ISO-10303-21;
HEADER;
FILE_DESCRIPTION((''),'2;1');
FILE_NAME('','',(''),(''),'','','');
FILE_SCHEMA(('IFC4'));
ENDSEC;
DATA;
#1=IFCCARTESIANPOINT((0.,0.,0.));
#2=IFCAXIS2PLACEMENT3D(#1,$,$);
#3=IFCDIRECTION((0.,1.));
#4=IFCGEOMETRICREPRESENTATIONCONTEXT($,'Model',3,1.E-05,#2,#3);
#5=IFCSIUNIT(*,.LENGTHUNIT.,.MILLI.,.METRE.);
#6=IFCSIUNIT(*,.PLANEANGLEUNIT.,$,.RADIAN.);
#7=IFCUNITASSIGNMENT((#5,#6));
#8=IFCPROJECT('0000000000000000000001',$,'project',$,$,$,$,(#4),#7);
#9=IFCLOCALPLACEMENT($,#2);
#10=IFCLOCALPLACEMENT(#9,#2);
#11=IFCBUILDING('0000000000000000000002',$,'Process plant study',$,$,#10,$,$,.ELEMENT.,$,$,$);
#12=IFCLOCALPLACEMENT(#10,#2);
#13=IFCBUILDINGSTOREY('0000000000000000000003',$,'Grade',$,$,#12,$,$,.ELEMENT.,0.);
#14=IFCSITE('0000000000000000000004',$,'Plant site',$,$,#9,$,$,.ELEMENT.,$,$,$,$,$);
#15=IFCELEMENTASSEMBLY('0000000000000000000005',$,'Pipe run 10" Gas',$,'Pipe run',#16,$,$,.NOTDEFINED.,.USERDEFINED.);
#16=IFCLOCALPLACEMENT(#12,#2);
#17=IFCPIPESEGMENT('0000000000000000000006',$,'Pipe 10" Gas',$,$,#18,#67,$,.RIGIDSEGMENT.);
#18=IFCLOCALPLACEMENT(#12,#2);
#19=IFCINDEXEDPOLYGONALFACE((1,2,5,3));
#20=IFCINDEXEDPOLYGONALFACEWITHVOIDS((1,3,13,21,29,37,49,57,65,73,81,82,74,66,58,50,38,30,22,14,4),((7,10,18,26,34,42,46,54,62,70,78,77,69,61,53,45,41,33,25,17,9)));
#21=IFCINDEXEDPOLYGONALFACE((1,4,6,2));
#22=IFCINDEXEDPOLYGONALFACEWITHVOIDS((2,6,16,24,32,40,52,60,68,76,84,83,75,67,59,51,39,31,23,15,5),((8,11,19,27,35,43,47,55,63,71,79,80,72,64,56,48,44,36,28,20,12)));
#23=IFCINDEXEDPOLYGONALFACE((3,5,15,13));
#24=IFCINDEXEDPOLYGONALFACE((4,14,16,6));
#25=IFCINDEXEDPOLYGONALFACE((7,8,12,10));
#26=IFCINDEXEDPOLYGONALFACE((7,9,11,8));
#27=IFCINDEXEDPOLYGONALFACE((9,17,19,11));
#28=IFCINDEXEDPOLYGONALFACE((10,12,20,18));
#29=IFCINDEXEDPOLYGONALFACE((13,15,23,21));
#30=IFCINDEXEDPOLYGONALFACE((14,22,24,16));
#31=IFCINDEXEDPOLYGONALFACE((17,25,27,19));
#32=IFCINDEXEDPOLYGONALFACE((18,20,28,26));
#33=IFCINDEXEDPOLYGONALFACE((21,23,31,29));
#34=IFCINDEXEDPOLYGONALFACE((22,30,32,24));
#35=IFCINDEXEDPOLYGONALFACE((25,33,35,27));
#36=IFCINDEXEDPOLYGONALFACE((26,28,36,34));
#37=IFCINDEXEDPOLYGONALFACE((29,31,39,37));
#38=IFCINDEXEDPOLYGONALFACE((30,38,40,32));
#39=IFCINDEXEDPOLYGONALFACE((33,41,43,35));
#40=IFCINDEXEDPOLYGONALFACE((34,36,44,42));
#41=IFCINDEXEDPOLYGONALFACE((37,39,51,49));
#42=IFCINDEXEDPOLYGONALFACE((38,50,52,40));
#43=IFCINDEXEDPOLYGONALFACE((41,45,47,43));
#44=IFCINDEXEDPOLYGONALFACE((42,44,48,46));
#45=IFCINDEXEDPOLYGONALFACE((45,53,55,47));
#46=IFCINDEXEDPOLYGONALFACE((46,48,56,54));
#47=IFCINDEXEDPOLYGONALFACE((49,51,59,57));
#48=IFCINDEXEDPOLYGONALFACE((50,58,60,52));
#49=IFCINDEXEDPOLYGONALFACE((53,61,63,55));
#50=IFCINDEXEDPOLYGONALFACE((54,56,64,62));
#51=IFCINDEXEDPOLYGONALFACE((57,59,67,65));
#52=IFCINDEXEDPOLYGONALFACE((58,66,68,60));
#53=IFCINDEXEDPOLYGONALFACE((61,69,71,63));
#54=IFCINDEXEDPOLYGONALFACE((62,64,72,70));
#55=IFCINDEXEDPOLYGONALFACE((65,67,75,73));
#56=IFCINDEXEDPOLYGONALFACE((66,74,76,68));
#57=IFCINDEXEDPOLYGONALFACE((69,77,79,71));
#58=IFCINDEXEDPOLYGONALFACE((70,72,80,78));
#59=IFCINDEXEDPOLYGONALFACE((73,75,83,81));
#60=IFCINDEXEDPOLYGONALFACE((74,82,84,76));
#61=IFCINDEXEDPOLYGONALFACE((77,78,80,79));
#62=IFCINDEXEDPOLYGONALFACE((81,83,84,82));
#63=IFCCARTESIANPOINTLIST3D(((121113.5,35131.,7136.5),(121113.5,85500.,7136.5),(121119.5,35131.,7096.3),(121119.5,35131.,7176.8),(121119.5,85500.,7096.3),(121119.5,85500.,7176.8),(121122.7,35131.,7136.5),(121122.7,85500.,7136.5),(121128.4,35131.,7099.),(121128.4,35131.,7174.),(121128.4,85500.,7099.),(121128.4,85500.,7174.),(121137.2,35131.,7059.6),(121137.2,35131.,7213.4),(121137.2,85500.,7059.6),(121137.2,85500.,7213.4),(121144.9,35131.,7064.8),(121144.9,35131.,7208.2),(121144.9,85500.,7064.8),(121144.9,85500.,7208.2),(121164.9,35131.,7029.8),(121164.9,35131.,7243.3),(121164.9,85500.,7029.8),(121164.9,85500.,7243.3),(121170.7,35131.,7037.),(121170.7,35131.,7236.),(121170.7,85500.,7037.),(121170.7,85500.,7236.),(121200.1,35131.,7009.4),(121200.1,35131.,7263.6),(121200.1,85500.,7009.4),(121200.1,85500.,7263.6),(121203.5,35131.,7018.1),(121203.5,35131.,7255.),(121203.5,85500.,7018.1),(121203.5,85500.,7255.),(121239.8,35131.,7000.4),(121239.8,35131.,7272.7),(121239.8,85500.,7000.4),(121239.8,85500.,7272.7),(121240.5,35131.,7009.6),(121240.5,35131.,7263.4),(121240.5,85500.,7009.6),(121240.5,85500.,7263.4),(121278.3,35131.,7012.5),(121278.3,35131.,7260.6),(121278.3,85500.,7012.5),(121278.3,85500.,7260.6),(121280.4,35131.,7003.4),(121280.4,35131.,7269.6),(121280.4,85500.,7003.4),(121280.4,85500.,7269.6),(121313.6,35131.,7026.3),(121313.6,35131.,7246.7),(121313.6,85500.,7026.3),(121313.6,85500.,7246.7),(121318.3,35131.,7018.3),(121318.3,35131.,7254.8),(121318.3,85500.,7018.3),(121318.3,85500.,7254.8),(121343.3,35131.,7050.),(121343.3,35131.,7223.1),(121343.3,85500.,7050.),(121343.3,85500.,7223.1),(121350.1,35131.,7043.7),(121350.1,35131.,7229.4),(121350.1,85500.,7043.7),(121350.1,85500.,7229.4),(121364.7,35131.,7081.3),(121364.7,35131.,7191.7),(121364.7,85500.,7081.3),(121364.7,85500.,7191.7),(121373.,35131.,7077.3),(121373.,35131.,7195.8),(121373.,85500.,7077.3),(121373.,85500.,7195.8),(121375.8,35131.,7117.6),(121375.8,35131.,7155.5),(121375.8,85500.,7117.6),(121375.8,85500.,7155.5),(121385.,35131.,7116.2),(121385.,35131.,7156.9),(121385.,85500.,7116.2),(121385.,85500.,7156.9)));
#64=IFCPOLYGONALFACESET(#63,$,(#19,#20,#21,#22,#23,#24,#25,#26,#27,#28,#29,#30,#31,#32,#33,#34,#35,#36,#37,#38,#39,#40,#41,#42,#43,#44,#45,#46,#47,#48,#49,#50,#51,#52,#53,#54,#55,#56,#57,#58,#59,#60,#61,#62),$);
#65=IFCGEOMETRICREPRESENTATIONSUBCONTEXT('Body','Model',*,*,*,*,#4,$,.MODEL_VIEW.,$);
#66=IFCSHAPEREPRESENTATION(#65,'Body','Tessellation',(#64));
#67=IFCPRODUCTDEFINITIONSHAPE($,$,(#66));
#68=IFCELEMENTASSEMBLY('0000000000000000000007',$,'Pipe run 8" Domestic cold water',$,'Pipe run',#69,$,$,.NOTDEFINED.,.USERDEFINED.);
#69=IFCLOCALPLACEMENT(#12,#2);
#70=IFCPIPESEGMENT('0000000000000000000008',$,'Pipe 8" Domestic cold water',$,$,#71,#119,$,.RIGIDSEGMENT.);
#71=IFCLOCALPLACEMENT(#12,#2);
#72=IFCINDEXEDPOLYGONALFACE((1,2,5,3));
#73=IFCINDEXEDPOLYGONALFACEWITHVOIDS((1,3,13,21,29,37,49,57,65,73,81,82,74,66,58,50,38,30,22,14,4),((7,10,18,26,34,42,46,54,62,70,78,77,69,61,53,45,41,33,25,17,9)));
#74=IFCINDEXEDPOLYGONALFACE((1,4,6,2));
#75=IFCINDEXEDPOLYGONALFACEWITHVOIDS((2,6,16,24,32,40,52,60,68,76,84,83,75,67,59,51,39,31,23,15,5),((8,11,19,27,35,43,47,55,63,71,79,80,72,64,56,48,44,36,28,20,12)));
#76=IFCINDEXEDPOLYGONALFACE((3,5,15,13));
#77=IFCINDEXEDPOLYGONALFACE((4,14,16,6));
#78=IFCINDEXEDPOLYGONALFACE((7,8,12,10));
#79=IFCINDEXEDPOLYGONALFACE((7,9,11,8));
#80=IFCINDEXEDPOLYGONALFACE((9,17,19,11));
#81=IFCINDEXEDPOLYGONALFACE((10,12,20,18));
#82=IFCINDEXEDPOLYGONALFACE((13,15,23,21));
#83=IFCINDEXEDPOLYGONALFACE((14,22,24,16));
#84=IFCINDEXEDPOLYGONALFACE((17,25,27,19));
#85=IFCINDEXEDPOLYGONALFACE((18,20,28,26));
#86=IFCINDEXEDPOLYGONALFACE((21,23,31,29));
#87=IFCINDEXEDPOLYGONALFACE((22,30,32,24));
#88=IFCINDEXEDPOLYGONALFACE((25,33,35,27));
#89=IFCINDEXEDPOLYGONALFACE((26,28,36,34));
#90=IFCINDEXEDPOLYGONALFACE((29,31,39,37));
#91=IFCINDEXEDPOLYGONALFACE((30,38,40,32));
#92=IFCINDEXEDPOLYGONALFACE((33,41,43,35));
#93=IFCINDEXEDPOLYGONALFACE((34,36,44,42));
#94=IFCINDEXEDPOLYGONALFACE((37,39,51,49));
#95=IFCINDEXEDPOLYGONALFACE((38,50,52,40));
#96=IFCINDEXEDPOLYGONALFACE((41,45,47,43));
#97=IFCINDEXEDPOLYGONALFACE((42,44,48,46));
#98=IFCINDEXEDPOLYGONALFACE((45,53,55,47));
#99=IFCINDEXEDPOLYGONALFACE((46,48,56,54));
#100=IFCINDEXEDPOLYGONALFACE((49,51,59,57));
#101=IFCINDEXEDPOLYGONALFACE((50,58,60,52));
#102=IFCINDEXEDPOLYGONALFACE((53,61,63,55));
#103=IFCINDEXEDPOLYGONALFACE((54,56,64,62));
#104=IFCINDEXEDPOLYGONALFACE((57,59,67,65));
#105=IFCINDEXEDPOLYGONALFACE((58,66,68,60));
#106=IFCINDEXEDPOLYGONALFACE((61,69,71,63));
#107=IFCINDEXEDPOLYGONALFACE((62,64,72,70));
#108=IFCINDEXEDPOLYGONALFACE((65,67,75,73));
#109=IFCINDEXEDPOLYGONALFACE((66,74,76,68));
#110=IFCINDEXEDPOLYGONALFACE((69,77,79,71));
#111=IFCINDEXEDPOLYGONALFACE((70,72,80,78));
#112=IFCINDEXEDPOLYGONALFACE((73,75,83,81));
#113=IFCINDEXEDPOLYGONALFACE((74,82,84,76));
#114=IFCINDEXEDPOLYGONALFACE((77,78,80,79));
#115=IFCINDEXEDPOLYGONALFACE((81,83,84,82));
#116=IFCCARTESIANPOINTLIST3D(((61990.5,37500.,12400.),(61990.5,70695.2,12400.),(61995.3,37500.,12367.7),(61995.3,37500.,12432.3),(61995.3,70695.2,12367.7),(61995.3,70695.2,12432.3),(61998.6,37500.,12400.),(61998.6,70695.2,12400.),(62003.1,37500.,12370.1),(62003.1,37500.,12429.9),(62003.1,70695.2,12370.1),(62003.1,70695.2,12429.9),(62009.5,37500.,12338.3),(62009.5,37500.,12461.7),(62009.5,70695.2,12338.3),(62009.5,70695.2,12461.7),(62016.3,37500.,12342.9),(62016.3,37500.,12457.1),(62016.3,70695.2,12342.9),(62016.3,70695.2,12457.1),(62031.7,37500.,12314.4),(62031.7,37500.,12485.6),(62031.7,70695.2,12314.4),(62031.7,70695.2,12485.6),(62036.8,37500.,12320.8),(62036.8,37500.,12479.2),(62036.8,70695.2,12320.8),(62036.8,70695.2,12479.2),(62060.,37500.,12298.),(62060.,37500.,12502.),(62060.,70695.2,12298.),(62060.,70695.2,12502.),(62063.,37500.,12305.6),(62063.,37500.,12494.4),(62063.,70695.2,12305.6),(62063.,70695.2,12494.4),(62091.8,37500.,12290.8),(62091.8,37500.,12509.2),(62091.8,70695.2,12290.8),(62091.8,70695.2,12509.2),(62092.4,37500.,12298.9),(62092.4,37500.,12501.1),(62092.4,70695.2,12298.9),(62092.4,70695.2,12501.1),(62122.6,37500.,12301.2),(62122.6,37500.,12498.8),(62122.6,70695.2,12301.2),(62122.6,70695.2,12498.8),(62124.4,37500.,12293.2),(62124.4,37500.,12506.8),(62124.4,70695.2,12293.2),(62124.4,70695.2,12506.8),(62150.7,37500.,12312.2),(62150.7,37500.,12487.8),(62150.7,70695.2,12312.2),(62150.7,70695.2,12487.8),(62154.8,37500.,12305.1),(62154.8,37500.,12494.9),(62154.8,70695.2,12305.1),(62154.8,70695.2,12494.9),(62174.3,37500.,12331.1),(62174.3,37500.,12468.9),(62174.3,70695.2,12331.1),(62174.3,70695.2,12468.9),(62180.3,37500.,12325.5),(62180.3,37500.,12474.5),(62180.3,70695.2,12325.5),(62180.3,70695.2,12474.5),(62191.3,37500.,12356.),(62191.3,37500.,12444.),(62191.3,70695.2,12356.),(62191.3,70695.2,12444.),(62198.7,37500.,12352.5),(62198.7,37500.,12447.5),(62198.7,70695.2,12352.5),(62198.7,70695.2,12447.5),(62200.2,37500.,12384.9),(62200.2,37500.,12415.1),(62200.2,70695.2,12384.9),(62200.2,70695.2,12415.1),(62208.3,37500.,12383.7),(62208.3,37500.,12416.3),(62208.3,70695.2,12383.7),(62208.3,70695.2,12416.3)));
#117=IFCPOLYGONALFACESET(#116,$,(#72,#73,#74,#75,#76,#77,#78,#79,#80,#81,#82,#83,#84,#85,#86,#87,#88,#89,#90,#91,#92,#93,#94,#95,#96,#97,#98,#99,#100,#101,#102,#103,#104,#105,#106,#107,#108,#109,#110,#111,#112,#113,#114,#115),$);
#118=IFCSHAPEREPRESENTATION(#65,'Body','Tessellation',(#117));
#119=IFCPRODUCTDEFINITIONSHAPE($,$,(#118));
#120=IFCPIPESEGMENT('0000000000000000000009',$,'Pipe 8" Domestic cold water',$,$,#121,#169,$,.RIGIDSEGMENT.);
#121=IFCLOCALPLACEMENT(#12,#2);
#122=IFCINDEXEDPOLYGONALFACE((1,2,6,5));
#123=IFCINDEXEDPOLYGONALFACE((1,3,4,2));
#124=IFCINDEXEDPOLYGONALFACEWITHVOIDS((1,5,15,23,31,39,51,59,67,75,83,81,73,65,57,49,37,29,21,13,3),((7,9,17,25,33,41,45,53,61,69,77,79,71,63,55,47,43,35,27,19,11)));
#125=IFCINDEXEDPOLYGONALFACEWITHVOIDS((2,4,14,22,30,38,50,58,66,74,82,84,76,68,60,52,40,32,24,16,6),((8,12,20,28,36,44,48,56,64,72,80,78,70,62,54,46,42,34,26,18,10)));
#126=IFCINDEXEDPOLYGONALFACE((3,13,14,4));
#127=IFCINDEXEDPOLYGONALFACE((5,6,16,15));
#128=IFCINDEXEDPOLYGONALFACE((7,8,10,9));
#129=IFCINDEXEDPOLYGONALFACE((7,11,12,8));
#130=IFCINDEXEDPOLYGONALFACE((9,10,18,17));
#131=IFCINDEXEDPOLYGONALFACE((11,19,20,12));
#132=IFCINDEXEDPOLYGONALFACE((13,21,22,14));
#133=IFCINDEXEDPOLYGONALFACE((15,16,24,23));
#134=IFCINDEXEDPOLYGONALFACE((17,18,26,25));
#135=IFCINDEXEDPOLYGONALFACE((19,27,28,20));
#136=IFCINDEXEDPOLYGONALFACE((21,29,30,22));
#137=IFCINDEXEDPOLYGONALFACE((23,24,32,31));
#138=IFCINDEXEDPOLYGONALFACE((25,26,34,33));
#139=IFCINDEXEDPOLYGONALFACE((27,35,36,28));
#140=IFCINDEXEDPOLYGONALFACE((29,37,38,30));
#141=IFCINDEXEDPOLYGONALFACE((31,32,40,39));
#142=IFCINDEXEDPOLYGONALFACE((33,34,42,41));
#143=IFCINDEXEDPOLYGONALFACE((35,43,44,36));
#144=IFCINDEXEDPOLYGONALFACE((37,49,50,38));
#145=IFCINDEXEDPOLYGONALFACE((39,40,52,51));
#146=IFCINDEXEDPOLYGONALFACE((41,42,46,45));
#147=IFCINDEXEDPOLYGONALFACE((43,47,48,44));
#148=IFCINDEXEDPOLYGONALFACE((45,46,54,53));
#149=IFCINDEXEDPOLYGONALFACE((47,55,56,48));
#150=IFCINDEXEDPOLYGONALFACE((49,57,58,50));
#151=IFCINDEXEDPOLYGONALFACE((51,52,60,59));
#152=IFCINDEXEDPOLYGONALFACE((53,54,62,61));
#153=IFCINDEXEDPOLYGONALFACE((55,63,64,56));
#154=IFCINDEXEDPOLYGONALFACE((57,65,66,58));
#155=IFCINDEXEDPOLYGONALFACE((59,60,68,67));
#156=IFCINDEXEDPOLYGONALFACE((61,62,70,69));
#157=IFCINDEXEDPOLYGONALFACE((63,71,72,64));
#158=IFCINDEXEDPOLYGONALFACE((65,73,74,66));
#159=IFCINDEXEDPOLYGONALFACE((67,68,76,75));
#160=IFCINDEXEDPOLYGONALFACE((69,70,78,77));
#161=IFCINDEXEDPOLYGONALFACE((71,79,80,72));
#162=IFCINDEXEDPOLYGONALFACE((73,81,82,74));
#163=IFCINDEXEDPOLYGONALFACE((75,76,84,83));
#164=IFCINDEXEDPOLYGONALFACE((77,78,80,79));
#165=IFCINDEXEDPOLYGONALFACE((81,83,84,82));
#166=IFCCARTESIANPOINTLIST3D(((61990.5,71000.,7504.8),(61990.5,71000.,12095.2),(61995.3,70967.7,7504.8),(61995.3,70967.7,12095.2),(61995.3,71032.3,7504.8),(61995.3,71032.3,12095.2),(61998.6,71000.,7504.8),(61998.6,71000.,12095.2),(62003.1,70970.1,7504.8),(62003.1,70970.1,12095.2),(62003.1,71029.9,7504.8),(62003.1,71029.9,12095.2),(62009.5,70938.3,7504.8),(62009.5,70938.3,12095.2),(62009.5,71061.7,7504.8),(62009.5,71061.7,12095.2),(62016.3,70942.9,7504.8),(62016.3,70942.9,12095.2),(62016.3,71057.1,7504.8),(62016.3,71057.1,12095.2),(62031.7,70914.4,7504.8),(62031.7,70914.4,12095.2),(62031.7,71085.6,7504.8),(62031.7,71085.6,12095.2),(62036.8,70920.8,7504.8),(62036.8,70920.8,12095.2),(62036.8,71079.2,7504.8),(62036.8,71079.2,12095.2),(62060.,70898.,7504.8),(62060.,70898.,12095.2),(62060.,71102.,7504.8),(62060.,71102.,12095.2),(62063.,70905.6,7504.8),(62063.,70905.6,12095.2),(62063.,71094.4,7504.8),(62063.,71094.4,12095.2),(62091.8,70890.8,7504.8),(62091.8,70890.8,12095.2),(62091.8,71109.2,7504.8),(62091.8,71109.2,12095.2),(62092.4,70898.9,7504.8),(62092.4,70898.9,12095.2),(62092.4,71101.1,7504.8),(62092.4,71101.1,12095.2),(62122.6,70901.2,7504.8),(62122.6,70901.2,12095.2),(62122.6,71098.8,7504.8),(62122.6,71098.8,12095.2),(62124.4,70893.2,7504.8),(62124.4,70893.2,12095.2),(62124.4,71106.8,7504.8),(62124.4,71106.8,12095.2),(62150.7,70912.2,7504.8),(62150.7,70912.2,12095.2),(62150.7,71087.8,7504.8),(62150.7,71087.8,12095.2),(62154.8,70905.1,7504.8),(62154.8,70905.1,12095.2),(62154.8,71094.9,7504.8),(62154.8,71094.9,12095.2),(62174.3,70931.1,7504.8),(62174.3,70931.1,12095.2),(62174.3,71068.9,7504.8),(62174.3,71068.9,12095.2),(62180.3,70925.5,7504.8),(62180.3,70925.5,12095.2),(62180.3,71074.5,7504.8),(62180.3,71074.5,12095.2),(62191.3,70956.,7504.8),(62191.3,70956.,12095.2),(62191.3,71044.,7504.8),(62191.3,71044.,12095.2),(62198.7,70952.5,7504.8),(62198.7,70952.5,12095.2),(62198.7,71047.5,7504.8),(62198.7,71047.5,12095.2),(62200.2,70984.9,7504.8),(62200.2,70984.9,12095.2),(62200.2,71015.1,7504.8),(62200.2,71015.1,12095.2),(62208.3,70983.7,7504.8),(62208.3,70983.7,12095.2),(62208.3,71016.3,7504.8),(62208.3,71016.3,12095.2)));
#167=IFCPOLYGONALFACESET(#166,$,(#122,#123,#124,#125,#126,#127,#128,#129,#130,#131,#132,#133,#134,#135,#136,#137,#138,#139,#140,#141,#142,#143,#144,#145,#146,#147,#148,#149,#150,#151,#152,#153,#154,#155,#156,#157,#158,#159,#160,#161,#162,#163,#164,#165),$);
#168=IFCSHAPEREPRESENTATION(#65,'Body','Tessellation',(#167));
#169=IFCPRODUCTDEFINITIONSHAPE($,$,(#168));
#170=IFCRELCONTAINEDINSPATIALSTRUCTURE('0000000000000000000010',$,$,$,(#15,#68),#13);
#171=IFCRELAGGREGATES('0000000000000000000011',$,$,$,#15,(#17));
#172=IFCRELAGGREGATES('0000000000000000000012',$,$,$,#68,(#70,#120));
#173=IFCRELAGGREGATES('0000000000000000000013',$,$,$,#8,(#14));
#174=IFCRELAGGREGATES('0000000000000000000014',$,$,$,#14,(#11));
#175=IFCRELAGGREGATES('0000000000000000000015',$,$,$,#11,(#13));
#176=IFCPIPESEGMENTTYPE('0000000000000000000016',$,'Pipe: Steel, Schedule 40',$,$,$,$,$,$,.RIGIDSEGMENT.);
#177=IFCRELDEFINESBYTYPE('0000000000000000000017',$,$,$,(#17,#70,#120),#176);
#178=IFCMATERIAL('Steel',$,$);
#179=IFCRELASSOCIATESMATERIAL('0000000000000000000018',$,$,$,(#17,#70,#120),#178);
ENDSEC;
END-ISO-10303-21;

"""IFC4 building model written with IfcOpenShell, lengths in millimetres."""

from ifc_helpers import new_model, si_unit, direction, frame, origin, origin_with_axes, origin_2d, place, context, subcontext, project, spatial, hollow_circle, extrude, material, type_object, element, aggregate, save


model = new_model("IFC4")

# Units and contexts
model_context = context("Model", 3, precision=1e-05, world=origin(), true_north=direction((0.0, 1.0)))
body_context = subcontext(model_context, "Body", "Model", "MODEL_VIEW")
ifc_project = project(units=[si_unit("LENGTHUNIT", "METRE", prefix="MILLI"), si_unit("PLANEANGLEUNIT", "RADIAN")], contexts=[model_context])

# Site, building, storey
site_placement = place(None, origin())
site = spatial("IfcSite", under=ifc_project, at=site_placement, Name="Plant site", CompositionType="ELEMENT")
building_placement = place(site_placement, origin())
building = spatial("IfcBuilding", under=site, at=building_placement, Name="Process plant study", CompositionType="ELEMENT")
storey_placement = place(building_placement, origin())
storey = spatial("IfcBuildingStorey", under=building, at=storey_placement, Name="Grade", CompositionType="ELEMENT", Elevation=0.0)

# Element assembly, pipe segment
assembly_1_placement = place(storey_placement, origin_with_axes())
assembly_1 = element("IfcElementAssembly", 1, at=assembly_1_placement, inside=storey, Name="Pipe run 10\" Gas", ObjectType="Pipe run", AssemblyPlace="NOTDEFINED", PredefinedType="USERDEFINED")
ifc_material = material(Name="Steel")
pipe_segment_type = type_object("IfcPipeSegmentType", Name="Pipe: Steel, Schedule 40", PredefinedType="RIGIDSEGMENT")
pipe_segment_1_placement = place(storey_placement, origin_with_axes())
pipe_segment_1 = element("IfcPipeSegment", 2, at=pipe_segment_1_placement, type_object=pipe_segment_type, material=ifc_material, Name="Pipe 10\" Gas", PredefinedType="RIGIDSEGMENT", context=body_context, shape_type="SweptSolid", body=[
    extrude(hollow_circle(Radius=136.5, WallThickness=9.3, at=origin_2d()), frame((121250.0, 35131.0, 7136.5), z_axis=(0.0, 1.0, 0.0), x_axis=(-1.0, 0.0, 0.0)), (0.0, 0.0, 1.0), 50369.0),
])

# Element assembly, pipe segments
assembly_2_placement = place(storey_placement, origin_with_axes())
assembly_2 = element("IfcElementAssembly", 3, at=assembly_2_placement, inside=storey, Name="Pipe run 8\" Domestic cold water", ObjectType="Pipe run", AssemblyPlace="NOTDEFINED", PredefinedType="USERDEFINED")
pipe_segment_2_placement = place(storey_placement, origin_with_axes())
pipe_segment_2 = element("IfcPipeSegment", 4, at=pipe_segment_2_placement, type_object=pipe_segment_type, material=ifc_material, Name="Pipe 8\" Domestic cold water", PredefinedType="RIGIDSEGMENT", context=body_context, shape_type="SweptSolid", body=[
    extrude(hollow_circle(Radius=109.5, WallThickness=8.2, at=origin_2d()), frame((62100.0, 37500.0, 12400.0), z_axis=(0.0, 1.0, 0.0), x_axis=(-1.0, 0.0, 0.0)), (0.0, 0.0, 1.0), 33195.2),
])
pipe_segment_3_placement = place(storey_placement, origin_with_axes())
pipe_segment_3 = element("IfcPipeSegment", 5, at=pipe_segment_3_placement, type_object=pipe_segment_type, material=ifc_material, Name="Pipe 8\" Domestic cold water", PredefinedType="RIGIDSEGMENT", context=body_context, shape_type="SweptSolid", body=[
    extrude(hollow_circle(Radius=109.5, WallThickness=8.2, at=origin_2d()), frame((62100.0, 71000.0, 12095.2), z_axis=(0.0, 0.0, -1.0), x_axis=(-1.0, 0.0, 0.0)), (0.0, 0.0, 1.0), 4590.4),
])

aggregate(assembly_1, [pipe_segment_1])
aggregate(assembly_2, [pipe_segment_2, pipe_segment_3])

save(model, "model.ifc")
